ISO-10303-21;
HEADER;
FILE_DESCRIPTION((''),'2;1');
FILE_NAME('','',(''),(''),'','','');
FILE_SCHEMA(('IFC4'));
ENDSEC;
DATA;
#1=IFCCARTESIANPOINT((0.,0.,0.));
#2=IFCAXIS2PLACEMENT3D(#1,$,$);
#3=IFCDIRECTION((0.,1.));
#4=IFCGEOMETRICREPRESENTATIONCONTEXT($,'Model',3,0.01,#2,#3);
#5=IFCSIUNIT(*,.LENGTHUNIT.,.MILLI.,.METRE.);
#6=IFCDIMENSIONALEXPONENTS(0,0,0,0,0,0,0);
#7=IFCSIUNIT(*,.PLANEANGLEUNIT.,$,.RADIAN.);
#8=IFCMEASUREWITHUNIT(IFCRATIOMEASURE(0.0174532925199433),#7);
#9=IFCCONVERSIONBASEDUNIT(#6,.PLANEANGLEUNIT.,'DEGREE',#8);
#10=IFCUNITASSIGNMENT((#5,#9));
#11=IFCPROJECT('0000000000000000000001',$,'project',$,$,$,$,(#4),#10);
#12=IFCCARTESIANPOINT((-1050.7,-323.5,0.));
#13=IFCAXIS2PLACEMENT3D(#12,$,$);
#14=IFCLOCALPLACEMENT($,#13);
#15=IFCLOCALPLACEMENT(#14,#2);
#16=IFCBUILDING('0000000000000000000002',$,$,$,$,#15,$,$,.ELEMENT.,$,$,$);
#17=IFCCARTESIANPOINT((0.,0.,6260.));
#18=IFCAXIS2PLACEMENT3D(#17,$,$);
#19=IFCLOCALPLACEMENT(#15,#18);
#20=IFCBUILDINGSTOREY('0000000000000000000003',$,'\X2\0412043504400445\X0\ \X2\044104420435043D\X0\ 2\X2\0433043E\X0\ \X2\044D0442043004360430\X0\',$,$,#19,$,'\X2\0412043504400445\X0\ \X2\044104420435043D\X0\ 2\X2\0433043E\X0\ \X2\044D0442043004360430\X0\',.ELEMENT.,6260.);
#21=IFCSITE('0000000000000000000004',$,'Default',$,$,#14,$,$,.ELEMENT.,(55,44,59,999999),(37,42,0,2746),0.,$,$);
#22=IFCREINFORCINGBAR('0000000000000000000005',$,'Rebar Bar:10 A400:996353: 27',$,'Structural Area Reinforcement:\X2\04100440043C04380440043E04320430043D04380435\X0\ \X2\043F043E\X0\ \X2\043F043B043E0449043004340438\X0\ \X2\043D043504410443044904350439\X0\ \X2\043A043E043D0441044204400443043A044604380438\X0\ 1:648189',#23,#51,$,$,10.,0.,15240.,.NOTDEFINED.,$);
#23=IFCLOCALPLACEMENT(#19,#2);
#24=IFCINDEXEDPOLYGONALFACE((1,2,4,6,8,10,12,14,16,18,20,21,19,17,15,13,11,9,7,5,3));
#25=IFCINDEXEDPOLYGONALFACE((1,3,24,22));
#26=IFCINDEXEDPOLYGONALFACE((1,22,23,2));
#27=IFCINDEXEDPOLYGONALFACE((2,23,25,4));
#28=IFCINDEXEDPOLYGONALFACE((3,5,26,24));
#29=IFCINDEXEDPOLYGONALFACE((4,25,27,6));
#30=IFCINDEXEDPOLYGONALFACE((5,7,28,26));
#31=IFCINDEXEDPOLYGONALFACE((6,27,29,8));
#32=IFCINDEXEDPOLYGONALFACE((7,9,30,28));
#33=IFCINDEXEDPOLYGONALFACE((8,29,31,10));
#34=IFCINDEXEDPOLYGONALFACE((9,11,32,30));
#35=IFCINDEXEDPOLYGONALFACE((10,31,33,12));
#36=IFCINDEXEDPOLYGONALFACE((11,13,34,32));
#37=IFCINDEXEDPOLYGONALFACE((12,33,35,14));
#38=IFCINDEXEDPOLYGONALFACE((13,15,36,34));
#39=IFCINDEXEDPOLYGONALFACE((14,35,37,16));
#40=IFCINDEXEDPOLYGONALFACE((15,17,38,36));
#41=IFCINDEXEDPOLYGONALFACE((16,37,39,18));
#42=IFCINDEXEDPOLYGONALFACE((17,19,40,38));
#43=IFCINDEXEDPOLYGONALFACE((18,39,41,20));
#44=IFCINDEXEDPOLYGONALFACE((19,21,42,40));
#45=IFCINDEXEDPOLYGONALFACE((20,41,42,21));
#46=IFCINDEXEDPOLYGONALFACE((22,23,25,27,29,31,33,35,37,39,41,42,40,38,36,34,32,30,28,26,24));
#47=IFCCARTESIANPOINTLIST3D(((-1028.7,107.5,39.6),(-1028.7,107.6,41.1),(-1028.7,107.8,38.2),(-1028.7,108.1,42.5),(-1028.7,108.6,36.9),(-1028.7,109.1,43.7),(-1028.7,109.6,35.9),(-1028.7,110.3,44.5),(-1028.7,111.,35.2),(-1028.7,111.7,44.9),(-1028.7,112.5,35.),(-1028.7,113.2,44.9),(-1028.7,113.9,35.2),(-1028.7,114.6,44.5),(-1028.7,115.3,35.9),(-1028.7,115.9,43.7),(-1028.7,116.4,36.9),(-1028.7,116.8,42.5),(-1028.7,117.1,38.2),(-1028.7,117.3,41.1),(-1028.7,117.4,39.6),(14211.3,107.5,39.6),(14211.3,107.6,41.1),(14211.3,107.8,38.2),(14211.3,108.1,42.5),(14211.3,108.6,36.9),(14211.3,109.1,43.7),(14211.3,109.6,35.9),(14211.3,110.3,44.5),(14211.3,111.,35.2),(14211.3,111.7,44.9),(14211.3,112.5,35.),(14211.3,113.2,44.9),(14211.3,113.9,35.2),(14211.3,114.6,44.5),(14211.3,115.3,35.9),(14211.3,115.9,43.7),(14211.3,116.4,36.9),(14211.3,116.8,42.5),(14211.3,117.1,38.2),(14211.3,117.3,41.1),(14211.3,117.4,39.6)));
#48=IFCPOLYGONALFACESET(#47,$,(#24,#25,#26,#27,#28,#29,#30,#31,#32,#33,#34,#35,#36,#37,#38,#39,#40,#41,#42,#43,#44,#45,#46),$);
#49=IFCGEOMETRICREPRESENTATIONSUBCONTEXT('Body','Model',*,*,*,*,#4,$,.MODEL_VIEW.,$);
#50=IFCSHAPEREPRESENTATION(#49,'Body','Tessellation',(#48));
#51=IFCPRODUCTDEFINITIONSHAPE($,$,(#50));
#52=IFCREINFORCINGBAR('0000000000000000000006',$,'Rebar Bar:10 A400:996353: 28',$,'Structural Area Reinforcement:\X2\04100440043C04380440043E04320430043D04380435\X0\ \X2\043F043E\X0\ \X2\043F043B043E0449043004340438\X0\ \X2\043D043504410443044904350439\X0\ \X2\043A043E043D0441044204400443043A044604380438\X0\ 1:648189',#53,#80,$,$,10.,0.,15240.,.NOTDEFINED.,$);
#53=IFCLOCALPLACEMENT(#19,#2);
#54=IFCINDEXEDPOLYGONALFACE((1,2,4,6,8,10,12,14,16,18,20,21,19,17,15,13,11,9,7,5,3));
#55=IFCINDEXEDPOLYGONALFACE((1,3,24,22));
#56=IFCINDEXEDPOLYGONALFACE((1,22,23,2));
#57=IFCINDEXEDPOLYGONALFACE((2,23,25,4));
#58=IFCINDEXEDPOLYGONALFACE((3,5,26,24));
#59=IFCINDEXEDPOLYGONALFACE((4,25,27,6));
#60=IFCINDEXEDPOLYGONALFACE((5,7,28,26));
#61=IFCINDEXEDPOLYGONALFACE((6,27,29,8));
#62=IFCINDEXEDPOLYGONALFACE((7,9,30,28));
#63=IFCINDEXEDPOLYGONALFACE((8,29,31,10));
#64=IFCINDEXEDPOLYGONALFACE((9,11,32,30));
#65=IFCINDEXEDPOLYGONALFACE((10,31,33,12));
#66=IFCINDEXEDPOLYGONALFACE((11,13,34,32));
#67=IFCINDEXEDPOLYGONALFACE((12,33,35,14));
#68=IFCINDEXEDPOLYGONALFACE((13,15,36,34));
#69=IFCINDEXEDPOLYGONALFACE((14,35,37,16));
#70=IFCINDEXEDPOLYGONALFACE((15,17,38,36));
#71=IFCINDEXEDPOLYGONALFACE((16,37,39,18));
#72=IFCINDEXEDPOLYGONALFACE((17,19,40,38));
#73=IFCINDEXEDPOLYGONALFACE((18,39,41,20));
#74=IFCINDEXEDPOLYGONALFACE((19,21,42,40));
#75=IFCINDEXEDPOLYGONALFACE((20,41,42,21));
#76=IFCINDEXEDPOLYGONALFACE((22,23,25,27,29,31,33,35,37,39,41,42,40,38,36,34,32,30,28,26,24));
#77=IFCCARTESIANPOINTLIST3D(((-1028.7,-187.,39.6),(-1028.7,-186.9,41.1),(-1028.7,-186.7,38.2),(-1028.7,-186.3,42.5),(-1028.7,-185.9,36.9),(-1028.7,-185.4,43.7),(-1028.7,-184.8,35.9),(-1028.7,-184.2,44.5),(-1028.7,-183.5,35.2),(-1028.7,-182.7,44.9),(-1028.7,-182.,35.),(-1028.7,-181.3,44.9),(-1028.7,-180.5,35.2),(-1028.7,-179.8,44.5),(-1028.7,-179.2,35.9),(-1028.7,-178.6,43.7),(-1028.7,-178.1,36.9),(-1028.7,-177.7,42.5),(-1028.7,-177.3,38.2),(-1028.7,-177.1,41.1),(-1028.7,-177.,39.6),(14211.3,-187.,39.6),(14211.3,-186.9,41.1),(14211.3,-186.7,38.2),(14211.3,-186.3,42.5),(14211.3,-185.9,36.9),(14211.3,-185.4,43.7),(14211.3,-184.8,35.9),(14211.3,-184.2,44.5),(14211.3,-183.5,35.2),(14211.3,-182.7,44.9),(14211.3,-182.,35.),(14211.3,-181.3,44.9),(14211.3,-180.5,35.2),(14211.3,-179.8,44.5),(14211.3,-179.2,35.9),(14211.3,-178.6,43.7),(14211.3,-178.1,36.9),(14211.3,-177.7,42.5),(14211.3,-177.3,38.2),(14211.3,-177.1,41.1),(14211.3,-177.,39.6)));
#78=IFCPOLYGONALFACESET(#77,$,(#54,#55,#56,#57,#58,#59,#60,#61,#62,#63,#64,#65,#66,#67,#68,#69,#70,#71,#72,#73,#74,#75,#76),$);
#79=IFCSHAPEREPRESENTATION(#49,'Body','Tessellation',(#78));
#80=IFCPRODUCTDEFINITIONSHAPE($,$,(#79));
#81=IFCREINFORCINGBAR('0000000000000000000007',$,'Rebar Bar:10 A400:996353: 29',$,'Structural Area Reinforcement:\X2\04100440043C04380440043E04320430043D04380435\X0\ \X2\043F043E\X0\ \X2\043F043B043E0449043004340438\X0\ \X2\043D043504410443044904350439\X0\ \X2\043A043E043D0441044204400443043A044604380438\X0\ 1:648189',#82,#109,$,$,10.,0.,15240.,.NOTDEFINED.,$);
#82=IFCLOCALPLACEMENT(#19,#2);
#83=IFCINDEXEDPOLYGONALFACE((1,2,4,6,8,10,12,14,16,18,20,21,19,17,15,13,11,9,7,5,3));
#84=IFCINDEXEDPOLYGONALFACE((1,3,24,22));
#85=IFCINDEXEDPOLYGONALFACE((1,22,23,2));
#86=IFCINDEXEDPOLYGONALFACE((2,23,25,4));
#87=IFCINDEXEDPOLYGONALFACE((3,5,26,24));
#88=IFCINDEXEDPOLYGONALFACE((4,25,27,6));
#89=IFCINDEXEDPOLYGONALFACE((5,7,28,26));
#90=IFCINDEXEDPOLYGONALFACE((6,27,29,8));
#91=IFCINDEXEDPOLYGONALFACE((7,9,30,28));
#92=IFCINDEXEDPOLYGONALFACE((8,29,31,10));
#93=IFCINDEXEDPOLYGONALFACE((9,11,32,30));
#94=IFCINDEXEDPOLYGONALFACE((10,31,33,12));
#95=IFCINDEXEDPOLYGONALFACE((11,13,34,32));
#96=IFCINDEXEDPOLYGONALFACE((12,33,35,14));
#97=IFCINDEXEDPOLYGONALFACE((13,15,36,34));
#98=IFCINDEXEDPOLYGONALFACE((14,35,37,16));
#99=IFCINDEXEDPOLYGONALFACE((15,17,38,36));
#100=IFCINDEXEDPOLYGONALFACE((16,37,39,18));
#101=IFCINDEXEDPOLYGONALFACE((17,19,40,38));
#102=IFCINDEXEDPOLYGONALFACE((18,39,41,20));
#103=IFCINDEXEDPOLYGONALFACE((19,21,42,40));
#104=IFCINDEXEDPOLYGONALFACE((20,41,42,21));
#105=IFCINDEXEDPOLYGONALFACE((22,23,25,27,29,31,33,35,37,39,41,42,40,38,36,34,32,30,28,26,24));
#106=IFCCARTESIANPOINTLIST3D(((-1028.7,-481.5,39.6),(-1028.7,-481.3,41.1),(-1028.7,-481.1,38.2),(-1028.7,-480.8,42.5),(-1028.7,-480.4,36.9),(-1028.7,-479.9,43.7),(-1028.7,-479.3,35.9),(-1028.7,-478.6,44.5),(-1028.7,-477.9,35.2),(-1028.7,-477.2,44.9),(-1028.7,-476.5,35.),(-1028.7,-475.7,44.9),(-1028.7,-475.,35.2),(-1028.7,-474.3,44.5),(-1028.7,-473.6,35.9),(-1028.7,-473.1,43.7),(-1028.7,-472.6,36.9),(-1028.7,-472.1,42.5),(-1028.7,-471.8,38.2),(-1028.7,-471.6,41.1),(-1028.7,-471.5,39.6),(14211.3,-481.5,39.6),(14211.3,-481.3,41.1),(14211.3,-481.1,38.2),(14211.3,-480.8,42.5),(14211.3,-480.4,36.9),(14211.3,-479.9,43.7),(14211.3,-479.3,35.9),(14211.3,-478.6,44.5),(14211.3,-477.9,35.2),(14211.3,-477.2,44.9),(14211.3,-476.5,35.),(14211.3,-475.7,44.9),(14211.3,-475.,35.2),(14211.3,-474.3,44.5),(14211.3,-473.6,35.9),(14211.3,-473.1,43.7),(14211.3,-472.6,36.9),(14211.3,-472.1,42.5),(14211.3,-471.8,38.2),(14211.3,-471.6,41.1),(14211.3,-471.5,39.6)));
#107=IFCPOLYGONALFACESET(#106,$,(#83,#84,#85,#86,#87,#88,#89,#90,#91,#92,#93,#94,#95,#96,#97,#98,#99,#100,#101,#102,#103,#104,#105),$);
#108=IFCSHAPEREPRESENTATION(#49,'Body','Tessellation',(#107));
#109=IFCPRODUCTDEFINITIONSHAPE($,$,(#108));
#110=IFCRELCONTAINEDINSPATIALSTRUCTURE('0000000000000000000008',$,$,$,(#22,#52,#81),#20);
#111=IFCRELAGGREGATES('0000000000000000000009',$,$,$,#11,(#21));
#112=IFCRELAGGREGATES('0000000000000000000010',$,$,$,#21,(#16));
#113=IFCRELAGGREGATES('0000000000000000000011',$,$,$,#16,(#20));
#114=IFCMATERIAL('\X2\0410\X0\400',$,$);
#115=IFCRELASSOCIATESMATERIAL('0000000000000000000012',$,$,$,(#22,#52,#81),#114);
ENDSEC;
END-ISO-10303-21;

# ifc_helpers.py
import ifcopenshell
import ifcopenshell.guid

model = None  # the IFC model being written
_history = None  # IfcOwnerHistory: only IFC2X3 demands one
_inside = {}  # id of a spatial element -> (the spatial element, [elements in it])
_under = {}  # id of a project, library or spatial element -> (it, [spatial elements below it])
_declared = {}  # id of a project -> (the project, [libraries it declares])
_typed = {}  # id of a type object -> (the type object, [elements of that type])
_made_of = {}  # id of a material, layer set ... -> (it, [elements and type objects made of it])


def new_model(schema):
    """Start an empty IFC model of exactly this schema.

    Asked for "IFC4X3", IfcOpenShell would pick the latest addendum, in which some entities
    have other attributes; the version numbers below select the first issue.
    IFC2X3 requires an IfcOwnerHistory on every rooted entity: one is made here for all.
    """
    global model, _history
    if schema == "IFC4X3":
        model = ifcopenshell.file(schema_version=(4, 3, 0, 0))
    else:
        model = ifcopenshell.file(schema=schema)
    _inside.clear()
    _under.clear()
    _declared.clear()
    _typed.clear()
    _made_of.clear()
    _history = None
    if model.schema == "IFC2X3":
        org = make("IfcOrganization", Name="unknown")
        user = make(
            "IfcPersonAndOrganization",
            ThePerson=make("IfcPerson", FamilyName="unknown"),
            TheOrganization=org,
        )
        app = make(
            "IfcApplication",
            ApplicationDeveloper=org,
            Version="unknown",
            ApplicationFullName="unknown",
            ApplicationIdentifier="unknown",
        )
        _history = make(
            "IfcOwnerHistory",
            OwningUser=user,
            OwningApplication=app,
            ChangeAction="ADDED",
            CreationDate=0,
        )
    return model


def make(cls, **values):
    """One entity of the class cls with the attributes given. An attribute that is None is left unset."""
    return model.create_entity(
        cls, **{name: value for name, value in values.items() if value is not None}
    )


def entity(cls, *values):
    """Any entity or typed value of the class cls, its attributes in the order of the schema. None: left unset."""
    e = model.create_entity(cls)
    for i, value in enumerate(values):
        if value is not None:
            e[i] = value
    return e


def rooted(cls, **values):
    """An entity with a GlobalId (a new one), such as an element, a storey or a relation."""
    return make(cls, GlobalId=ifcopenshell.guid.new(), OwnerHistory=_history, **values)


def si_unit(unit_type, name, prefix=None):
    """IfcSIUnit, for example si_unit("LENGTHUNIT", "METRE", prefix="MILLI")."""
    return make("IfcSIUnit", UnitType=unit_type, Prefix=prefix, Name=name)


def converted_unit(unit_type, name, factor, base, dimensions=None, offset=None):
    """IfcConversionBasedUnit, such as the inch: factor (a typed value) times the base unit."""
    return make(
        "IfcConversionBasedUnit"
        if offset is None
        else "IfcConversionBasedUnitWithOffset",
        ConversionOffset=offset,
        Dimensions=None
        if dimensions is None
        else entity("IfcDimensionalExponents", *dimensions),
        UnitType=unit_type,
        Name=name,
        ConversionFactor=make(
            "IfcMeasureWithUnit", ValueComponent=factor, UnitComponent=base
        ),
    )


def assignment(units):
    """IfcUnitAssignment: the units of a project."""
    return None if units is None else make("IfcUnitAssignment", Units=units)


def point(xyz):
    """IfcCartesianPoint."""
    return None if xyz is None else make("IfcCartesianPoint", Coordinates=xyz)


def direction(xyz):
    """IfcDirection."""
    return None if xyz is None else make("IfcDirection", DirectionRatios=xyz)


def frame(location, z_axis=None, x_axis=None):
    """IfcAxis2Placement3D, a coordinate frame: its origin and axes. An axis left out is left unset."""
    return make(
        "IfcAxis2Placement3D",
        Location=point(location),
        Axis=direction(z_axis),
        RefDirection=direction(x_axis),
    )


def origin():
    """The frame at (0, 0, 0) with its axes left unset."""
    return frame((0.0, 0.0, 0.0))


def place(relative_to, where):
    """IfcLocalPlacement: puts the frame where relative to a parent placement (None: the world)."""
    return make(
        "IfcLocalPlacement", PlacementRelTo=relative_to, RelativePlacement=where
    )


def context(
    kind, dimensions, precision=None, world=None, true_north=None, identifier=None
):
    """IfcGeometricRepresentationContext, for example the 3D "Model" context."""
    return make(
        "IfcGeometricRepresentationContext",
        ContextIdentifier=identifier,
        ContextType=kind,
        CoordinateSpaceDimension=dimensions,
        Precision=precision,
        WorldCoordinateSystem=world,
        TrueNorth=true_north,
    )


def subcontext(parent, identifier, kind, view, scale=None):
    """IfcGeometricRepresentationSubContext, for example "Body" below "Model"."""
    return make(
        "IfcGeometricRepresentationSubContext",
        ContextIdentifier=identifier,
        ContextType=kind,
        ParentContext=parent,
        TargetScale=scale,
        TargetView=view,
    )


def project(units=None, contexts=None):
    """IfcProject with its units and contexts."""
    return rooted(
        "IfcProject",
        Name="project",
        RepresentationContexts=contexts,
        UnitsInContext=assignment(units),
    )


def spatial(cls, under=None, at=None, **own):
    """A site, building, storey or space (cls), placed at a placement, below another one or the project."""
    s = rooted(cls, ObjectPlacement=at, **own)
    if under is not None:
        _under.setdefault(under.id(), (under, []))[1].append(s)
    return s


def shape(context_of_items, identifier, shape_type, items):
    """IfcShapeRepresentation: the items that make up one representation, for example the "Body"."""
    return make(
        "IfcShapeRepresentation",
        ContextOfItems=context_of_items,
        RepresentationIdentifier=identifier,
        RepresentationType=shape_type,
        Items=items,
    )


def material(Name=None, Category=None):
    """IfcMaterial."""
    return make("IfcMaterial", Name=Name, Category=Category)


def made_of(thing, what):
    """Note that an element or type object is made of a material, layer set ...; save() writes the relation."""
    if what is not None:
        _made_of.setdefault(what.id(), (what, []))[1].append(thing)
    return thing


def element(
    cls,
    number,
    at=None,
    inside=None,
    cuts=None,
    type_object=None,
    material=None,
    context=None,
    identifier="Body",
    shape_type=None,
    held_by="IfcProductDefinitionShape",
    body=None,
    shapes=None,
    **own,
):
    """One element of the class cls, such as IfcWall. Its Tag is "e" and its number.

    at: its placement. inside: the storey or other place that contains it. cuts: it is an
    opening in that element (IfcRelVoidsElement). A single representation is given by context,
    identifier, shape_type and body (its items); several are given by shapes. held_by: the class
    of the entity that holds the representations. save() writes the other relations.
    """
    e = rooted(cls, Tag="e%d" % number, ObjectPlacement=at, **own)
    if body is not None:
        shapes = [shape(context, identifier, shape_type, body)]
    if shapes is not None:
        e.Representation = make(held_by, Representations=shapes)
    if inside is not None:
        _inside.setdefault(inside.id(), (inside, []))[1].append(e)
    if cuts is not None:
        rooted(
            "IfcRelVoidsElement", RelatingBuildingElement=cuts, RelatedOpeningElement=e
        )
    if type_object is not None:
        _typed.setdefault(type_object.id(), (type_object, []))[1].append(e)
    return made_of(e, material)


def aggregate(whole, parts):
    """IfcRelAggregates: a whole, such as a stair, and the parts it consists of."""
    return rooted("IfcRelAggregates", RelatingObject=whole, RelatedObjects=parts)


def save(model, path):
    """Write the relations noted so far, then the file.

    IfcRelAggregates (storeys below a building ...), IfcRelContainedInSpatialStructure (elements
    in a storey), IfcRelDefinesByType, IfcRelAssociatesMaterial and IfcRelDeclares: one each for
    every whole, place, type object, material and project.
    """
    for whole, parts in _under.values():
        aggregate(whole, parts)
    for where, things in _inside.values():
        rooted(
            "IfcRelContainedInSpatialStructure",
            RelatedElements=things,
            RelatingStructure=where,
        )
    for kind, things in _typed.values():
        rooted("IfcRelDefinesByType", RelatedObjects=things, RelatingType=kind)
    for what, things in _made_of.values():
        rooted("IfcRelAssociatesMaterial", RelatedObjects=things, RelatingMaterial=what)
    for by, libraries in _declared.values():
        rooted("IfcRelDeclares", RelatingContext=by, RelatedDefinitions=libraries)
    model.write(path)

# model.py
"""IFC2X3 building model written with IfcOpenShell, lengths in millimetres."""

from ifc_helpers import new_model, entity, si_unit, converted_unit, direction, frame, origin, place, context, subcontext, project, spatial, material, element, save


model = new_model("IFC2X3")

# Units and contexts
model_context = context("Model", 3, precision=0.01, world=origin(), true_north=direction((0.0, 1.0)))
body_context = subcontext(model_context, "Body", "Model", "MODEL_VIEW")
ifc_project = project(units=[si_unit("LENGTHUNIT", "METRE", prefix="MILLI"), converted_unit("PLANEANGLEUNIT", "DEGREE", entity("IfcRatioMeasure", 0.0174532925199433), si_unit("PLANEANGLEUNIT", "RADIAN"), dimensions=[0, 0, 0, 0, 0, 0, 0])], contexts=[model_context])

# Site, building, storey
site_placement = place(None, frame((-1050.7, -323.5, 0.0)))
site = spatial("IfcSite", under=ifc_project, at=site_placement, Name="Default", CompositionType="ELEMENT", RefLatitude=(55, 44, 59, 999999), RefLongitude=(37, 42, 0, 2746), RefElevation=0.0)
building_placement = place(site_placement, origin())
building = spatial("IfcBuilding", under=site, at=building_placement, CompositionType="ELEMENT")
storey_placement = place(building_placement, frame((0.0, 0.0, 6260.0)))
storey = spatial("IfcBuildingStorey", under=building, at=storey_placement, Name="Верх стен 2го этажа", LongName="Верх стен 2го этажа", CompositionType="ELEMENT", Elevation=6260.0)

# Reinforcing bars
ifc_material = material(Name="А400")
reinforcing_bar_1_placement = place(storey_placement, origin())
element("IfcReinforcingBar", 1, at=reinforcing_bar_1_placement, inside=storey, material=ifc_material, Name="Rebar Bar:10 A400:996353: 27", ObjectType="Structural Area Reinforcement:Армирование по площади несущей конструкции 1:648189", BarLength=15240.0, BarRole="NOTDEFINED", CrossSectionArea=0.0, NominalDiameter=10.0, context=body_context, shape_type="AdvancedSweptSolid", body=[
    entity("IfcSweptDiskSolid", entity("IfcCompositeCurve", [entity("IfcCompositeCurveSegment", "CONTINUOUS", True, entity("IfcPolyline", [entity("IfcCartesianPoint", [14211.3, 112.5, 40.0]), entity("IfcCartesianPoint", [-1028.7, 112.5, 40.0])]))], False), 5.0, None, 0.0, 1.0),
])
reinforcing_bar_2_placement = place(storey_placement, origin())
element("IfcReinforcingBar", 2, at=reinforcing_bar_2_placement, inside=storey, material=ifc_material, Name="Rebar Bar:10 A400:996353: 28", ObjectType="Structural Area Reinforcement:Армирование по площади несущей конструкции 1:648189", BarLength=15240.0, BarRole="NOTDEFINED", CrossSectionArea=0.0, NominalDiameter=10.0, context=body_context, shape_type="AdvancedSweptSolid", body=[
    entity("IfcSweptDiskSolid", entity("IfcCompositeCurve", [entity("IfcCompositeCurveSegment", "CONTINUOUS", True, entity("IfcPolyline", [entity("IfcCartesianPoint", [14211.3, -182.0, 40.0]), entity("IfcCartesianPoint", [-1028.7, -182.0, 40.0])]))], False), 5.0, None, 0.0, 1.0),
])
reinforcing_bar_3_placement = place(storey_placement, origin())
element("IfcReinforcingBar", 3, at=reinforcing_bar_3_placement, inside=storey, material=ifc_material, Name="Rebar Bar:10 A400:996353: 29", ObjectType="Structural Area Reinforcement:Армирование по площади несущей конструкции 1:648189", BarLength=15240.0, BarRole="NOTDEFINED", CrossSectionArea=0.0, NominalDiameter=10.0, context=body_context, shape_type="AdvancedSweptSolid", body=[
    entity("IfcSweptDiskSolid", entity("IfcCompositeCurve", [entity("IfcCompositeCurveSegment", "CONTINUOUS", True, entity("IfcPolyline", [entity("IfcCartesianPoint", [14211.3, -476.5, 40.0]), entity("IfcCartesianPoint", [-1028.7, -476.5, 40.0])]))], False), 5.0, None, 0.0, 1.0),
])

save(model, "model.ifc")
